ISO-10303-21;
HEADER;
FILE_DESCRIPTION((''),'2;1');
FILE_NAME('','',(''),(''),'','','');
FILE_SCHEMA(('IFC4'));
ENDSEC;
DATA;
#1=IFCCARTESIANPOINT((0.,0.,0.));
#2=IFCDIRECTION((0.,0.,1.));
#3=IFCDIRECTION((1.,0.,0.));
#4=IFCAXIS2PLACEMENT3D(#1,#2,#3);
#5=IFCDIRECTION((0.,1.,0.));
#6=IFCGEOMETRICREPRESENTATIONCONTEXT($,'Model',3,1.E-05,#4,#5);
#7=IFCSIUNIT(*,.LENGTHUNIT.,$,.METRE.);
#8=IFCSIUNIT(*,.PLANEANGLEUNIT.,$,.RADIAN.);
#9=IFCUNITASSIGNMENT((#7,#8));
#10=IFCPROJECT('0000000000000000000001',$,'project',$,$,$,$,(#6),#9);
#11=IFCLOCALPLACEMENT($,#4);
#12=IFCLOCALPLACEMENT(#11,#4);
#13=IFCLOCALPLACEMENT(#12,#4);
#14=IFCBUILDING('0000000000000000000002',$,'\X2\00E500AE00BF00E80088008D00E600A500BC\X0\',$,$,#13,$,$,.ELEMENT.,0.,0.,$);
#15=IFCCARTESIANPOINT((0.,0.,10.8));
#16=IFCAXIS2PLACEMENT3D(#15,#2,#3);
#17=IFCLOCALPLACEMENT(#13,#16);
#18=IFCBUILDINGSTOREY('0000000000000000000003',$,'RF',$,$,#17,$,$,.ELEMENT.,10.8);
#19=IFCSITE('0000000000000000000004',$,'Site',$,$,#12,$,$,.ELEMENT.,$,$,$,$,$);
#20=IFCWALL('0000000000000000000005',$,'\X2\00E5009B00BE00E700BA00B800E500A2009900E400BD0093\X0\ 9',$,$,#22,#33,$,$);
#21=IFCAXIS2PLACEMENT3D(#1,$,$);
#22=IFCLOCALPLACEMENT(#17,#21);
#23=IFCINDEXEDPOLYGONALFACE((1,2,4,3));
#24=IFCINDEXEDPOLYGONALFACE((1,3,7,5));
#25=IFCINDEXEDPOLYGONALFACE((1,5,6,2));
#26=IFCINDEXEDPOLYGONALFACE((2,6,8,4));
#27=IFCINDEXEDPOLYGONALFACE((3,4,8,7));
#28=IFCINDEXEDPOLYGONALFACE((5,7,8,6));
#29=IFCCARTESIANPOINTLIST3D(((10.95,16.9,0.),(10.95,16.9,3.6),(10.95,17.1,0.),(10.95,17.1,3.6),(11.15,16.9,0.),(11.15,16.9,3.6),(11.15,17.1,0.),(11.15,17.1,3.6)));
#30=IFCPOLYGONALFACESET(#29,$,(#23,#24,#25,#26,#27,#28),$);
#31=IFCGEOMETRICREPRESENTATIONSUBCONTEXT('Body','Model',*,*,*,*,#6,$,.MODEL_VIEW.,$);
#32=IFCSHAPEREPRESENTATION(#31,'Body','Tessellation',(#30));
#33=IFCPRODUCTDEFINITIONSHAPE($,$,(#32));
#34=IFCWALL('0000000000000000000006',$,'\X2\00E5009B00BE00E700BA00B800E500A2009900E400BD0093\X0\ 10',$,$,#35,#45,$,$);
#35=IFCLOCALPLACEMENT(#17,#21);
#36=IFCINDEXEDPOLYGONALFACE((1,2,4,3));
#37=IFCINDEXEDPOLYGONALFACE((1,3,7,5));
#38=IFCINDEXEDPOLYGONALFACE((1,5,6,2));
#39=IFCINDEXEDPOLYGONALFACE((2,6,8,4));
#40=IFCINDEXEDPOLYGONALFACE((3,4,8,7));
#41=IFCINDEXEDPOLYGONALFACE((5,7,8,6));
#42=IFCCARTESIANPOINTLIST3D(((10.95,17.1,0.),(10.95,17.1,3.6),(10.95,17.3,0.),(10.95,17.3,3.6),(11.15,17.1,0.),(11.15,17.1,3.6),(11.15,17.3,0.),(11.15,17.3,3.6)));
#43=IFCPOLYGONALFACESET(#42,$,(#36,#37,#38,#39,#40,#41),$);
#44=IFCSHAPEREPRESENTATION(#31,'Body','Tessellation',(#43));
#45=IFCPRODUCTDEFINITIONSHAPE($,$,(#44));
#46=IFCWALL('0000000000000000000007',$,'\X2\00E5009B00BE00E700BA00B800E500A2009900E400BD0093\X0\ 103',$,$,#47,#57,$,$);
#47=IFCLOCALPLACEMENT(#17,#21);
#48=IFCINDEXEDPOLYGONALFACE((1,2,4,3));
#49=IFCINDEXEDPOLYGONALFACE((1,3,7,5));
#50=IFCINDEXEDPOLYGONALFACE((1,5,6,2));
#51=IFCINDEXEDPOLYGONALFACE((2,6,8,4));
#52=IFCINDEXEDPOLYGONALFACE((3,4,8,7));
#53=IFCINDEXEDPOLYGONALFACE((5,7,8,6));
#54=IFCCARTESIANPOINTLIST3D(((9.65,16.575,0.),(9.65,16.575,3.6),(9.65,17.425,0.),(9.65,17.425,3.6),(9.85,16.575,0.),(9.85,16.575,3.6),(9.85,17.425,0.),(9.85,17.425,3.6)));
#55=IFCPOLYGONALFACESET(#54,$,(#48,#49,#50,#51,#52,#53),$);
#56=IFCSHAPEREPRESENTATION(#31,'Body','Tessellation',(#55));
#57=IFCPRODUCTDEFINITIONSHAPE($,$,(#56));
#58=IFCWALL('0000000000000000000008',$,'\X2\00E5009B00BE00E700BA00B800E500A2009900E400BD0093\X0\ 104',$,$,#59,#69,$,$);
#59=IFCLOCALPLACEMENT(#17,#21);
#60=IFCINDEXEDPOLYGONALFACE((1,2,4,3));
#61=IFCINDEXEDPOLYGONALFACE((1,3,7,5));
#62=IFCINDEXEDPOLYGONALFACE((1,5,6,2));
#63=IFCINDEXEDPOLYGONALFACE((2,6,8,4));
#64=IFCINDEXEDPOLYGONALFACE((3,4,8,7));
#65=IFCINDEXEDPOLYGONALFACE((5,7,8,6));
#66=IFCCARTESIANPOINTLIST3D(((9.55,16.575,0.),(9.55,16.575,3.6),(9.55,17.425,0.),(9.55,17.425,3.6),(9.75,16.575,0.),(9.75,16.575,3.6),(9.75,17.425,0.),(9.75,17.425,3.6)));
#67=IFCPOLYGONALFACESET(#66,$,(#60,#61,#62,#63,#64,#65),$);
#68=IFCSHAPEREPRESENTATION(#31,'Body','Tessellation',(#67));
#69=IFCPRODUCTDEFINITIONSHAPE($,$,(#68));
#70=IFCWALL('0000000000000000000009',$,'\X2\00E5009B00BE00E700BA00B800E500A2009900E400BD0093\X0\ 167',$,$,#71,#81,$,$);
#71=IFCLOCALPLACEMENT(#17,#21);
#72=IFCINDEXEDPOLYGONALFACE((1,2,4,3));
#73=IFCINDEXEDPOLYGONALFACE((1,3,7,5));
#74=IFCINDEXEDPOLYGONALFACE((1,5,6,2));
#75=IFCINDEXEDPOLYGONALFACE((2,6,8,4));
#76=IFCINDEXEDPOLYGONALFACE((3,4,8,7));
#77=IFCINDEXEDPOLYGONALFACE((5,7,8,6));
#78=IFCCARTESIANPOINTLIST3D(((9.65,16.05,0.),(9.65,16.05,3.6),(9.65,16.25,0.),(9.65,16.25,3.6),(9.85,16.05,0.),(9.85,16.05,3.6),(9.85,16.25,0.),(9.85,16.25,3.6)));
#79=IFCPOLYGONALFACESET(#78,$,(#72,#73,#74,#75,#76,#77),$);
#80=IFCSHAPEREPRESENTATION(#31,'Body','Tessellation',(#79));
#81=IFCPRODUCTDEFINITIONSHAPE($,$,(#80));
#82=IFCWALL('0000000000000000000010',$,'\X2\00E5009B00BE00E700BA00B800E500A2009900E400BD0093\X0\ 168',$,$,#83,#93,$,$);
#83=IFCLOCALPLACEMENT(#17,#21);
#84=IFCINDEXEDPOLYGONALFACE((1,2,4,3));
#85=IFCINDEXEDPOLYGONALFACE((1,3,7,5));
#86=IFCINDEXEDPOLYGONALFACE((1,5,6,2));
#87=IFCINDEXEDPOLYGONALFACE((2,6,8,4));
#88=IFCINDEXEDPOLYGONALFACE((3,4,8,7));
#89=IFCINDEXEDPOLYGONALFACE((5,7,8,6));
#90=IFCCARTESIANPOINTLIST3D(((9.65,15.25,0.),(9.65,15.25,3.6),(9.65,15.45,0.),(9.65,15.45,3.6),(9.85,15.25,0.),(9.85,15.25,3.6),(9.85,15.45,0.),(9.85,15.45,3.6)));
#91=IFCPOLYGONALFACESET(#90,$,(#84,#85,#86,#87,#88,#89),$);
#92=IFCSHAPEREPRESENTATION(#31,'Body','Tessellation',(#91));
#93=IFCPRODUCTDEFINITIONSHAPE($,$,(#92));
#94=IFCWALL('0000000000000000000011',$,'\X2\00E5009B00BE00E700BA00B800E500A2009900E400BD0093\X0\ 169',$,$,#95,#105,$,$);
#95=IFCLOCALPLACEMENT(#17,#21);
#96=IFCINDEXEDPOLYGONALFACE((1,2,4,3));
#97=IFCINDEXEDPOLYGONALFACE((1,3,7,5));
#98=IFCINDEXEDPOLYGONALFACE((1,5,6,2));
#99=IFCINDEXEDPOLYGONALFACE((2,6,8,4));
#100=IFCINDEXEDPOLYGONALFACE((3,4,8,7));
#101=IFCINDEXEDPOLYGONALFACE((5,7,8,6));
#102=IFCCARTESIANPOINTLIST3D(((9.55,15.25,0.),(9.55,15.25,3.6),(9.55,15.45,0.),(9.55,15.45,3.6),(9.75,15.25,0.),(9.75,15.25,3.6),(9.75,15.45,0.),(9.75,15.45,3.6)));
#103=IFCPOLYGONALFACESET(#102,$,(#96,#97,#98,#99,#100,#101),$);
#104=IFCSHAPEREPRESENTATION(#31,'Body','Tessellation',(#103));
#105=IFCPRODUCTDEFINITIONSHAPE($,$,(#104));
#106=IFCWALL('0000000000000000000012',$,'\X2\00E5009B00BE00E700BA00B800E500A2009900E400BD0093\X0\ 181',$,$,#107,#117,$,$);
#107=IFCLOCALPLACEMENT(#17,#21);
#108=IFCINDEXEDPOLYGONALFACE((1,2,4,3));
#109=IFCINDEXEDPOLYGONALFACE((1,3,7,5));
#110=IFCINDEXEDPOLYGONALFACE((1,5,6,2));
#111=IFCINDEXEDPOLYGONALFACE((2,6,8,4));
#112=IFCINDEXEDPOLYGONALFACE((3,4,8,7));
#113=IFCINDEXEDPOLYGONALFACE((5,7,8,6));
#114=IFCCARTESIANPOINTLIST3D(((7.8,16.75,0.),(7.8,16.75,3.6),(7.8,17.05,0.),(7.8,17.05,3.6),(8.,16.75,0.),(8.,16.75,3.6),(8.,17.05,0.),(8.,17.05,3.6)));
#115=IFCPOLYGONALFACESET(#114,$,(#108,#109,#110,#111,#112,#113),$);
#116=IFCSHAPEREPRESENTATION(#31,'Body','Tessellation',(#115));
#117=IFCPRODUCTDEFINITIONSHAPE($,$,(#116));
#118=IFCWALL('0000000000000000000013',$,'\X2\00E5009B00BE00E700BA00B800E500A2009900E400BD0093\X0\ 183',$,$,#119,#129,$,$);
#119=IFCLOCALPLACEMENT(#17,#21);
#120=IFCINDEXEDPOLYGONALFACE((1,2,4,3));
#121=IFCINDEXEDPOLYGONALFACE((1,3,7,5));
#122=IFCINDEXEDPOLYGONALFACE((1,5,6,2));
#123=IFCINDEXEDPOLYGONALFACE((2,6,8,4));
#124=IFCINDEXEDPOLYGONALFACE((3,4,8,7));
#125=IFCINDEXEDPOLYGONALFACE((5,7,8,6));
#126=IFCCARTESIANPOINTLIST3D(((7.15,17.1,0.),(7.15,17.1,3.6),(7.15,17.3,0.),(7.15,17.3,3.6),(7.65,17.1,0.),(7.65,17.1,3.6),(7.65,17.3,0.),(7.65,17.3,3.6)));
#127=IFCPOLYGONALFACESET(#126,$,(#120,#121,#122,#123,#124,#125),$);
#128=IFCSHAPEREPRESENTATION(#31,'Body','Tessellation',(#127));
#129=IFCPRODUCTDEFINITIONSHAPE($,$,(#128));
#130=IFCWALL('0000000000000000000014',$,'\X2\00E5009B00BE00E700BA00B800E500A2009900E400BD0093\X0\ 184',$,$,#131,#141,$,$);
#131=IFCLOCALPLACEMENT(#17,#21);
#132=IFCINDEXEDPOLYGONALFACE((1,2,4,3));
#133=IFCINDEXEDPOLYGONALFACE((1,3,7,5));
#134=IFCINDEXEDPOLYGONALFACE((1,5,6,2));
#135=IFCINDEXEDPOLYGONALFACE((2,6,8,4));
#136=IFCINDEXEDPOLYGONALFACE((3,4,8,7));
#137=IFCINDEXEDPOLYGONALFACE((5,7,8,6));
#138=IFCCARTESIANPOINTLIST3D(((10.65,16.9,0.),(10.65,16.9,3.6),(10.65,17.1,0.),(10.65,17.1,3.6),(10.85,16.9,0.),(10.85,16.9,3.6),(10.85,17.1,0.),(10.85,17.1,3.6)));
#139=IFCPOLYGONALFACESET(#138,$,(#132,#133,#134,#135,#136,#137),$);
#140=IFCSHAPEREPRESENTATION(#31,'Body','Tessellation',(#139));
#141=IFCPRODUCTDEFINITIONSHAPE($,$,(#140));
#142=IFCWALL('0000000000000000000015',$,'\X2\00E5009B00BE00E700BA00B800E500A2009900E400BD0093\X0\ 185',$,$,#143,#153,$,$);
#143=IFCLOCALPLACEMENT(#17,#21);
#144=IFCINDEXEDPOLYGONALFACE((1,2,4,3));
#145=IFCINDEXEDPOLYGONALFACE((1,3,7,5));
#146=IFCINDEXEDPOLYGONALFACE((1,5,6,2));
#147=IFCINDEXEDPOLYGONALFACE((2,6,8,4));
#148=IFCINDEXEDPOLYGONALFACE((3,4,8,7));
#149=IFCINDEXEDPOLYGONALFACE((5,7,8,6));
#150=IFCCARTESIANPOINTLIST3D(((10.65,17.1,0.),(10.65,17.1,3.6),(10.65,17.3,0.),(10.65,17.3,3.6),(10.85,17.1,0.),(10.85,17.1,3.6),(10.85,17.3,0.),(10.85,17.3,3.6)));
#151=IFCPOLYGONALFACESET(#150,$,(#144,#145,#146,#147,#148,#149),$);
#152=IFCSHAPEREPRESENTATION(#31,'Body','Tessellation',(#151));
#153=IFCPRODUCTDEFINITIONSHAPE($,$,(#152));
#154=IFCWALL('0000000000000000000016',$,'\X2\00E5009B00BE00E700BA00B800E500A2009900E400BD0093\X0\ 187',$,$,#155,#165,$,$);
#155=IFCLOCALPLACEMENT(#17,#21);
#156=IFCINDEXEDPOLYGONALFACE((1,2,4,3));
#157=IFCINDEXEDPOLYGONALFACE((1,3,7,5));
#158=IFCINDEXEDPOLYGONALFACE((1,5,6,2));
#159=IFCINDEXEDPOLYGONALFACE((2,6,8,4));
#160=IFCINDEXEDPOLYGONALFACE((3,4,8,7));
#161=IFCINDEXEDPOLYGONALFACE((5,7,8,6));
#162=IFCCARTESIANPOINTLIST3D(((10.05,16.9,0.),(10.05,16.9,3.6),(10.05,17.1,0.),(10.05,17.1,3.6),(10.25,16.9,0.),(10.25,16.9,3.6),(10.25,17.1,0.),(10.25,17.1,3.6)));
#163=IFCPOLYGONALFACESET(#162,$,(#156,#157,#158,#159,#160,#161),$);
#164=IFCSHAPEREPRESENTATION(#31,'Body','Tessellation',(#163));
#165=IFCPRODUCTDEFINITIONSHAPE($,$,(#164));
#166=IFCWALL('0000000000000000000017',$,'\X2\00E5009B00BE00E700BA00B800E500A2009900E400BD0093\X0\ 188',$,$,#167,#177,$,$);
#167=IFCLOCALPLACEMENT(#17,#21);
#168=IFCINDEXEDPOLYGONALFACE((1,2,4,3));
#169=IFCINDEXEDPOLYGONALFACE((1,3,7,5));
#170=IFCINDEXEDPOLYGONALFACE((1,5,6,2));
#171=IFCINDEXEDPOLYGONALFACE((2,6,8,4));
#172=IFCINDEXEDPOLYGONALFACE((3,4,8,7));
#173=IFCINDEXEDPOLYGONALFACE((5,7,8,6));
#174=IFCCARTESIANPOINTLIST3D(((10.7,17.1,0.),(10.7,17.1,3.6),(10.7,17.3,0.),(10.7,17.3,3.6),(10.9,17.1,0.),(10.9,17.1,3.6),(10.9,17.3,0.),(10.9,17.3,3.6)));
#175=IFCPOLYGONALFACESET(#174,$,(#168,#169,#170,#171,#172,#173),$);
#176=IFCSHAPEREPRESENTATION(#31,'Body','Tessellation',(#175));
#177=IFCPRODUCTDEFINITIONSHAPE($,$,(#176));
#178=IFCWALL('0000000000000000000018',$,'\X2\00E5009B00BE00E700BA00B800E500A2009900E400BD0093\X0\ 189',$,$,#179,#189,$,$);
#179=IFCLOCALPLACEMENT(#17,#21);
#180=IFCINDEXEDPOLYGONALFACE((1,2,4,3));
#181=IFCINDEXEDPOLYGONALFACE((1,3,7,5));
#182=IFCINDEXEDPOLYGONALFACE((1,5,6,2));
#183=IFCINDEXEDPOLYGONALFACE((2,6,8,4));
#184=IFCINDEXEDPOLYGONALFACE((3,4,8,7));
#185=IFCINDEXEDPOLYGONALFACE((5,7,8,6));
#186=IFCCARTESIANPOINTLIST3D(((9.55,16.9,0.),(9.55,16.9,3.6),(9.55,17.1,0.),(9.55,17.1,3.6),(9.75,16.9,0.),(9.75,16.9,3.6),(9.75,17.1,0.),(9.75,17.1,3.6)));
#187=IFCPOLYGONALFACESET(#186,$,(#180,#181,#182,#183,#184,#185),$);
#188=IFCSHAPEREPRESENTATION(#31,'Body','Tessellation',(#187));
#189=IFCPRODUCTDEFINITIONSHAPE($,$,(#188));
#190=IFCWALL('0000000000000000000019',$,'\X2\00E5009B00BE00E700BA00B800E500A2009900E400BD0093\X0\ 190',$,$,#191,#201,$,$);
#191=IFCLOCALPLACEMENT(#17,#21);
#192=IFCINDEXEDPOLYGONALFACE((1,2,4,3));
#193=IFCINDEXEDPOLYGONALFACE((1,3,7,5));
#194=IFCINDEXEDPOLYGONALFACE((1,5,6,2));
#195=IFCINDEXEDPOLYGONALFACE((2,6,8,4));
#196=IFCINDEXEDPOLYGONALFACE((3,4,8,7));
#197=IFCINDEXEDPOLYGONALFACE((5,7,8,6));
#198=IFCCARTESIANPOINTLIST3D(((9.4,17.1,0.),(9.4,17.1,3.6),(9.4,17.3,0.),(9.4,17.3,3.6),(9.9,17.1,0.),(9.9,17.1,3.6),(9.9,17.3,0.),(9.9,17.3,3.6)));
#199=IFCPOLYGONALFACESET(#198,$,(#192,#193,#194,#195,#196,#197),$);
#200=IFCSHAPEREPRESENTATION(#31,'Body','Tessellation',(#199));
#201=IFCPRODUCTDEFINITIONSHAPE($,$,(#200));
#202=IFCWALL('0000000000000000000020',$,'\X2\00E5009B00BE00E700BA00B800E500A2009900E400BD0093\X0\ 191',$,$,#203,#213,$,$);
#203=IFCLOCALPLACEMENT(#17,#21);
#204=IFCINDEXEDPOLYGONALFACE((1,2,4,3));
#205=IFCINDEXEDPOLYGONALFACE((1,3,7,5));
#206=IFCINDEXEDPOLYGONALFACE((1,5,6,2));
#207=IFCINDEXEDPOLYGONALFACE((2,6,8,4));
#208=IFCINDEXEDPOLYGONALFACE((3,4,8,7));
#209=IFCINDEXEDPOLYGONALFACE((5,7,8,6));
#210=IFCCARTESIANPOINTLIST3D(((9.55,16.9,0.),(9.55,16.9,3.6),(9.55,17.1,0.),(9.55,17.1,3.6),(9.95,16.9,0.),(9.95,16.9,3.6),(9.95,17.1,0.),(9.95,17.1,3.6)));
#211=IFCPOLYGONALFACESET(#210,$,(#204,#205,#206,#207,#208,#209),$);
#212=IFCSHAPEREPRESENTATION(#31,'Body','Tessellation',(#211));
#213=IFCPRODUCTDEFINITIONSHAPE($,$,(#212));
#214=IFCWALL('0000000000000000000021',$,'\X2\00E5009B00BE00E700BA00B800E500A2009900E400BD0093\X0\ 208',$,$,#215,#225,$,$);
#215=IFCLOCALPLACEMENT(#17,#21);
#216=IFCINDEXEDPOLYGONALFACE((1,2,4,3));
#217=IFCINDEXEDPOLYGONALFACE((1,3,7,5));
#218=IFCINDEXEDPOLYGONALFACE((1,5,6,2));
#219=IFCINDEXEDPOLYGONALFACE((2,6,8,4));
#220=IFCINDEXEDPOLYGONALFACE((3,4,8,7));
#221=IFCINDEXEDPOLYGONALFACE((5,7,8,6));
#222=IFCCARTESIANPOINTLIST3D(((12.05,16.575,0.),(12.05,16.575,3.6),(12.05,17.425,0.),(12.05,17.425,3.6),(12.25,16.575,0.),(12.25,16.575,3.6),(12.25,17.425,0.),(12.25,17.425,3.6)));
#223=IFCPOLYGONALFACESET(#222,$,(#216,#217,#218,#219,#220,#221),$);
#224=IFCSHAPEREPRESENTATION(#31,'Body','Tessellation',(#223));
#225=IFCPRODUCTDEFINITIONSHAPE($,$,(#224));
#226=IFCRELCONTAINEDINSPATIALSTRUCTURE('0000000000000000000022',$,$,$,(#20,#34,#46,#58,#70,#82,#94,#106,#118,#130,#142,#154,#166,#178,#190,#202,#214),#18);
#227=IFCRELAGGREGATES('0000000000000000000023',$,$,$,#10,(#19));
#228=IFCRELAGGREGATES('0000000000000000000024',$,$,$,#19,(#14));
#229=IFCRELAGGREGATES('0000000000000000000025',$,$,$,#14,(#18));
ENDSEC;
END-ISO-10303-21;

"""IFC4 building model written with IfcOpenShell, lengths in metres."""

from ifc_helpers import new_model, si_unit, direction, frame, frame_2d, origin_with_axes, place, context, subcontext, project, spatial, rectangle, extrude, element, save


model = new_model("IFC4")

# Units and contexts
model_context = context("Model", 3, precision=1e-05, world=origin_with_axes(), true_north=direction((0.0, 1.0, 0.0)))
body_context = subcontext(model_context, "Body", "Model", "MODEL_VIEW")
ifc_project = project(units=[si_unit("LENGTHUNIT", "METRE"), si_unit("PLANEANGLEUNIT", "RADIAN")], contexts=[model_context])

# Site, building, storey
placement = place(None, origin_with_axes())
site_placement = place(placement, origin_with_axes())
site = spatial("IfcSite", under=ifc_project, at=site_placement, Name="Site", CompositionType="ELEMENT")
building_placement = place(site_placement, origin_with_axes())
building = spatial("IfcBuilding", under=site, at=building_placement, Name="å®¿è\u0088\u008dæ¥¼", CompositionType="ELEMENT", ElevationOfRefHeight=0.0, ElevationOfTerrain=0.0)
storey_placement = place(building_placement, frame((0.0, 0.0, 10.8), z_axis=(0.0, 0.0, 1.0), x_axis=(1.0, 0.0, 0.0)))
storey = spatial("IfcBuildingStorey", under=building, at=storey_placement, Name="RF", CompositionType="ELEMENT", Elevation=10.8)

# Walls
for number, where, z_axis, x_axis, name in (
    (1, (11.05, 17.0, 0.0), (0.0, 0.0, 1.0), (-1.0, 0.0, 0.0), "å\u009b¾çº¸å¢\u0099ä½\u0093 9"),
    (2, (11.05, 17.2, 0.0), (0.0, 0.0, 1.0), (-1.0, 0.0, 0.0), "å\u009b¾çº¸å¢\u0099ä½\u0093 10"),
):
    element("IfcWall", number, at=place(storey_placement, frame(where, z_axis=z_axis, x_axis=x_axis)), inside=storey, Name=name, context=body_context, shape_type="SweptSolid", body=[
        extrude(rectangle(XDim=0.2, YDim=0.2, at=frame_2d((0.0, 0.0), x_axis=(1.0, 0.0, 0.0))), frame((0.0, 0.0, 0.0), z_axis=(0.0, 0.0, 1.0)), (0.0, 0.0, 1.0), 3.6),
    ])
for number, where, z_axis, x_axis, name in (
    (3, (9.75, 17.0, 0.0), (0.0, 0.0, 1.0), (0.0, -1.0, 0.0), "å\u009b¾çº¸å¢\u0099ä½\u0093 103"),
    (4, (9.65, 17.0, 0.0), (0.0, 0.0, 1.0), (0.0, -1.0, 0.0), "å\u009b¾çº¸å¢\u0099ä½\u0093 104"),
):
    element("IfcWall", number, at=place(storey_placement, frame(where, z_axis=z_axis, x_axis=x_axis)), inside=storey, Name=name, context=body_context, shape_type="SweptSolid", body=[
        extrude(rectangle(XDim=0.85, YDim=0.2, at=frame_2d((0.0, 0.0), x_axis=(1.0, 0.0, 0.0))), frame((0.0, 0.0, 0.0), z_axis=(0.0, 0.0, 1.0)), (0.0, 0.0, 1.0), 3.6),
    ])
for number, where, z_axis, x_axis, name in (
    (5, (9.75, 16.15, 0.0), (0.0, 0.0, 1.0), (-1.0, 0.0, 0.0), "å\u009b¾çº¸å¢\u0099ä½\u0093 167"),
    (6, (9.75, 15.35, 0.0), (0.0, 0.0, 1.0), (0.0, -1.0, 0.0), "å\u009b¾çº¸å¢\u0099ä½\u0093 168"),
    (7, (9.65, 15.35, 0.0), (0.0, 0.0, 1.0), (0.0, -1.0, 0.0), "å\u009b¾çº¸å¢\u0099ä½\u0093 169"),
):
    element("IfcWall", number, at=place(storey_placement, frame(where, z_axis=z_axis, x_axis=x_axis)), inside=storey, Name=name, context=body_context, shape_type="SweptSolid", body=[
        extrude(rectangle(XDim=0.2, YDim=0.2, at=frame_2d((0.0, 0.0), x_axis=(1.0, 0.0, 0.0))), frame((0.0, 0.0, 0.0), z_axis=(0.0, 0.0, 1.0)), (0.0, 0.0, 1.0), 3.6),
    ])
wall_1_placement = place(storey_placement, frame((7.9, 16.9, 0.0), z_axis=(0.0, 0.0, 1.0), x_axis=(0.0, 1.0, 0.0)))
element("IfcWall", 8, at=wall_1_placement, inside=storey, Name="å\u009b¾çº¸å¢\u0099ä½\u0093 181", context=body_context, shape_type="SweptSolid", body=[
    extrude(rectangle(XDim=0.3, YDim=0.2, at=frame_2d((0.0, 0.0), x_axis=(1.0, 0.0, 0.0))), frame((0.0, 0.0, 0.0), z_axis=(0.0, 0.0, 1.0)), (0.0, 0.0, 1.0), 3.6),
])
wall_2_placement = place(storey_placement, frame((7.4, 17.2, 0.0), z_axis=(0.0, 0.0, 1.0), x_axis=(1.0, 0.0, 0.0)))
element("IfcWall", 9, at=wall_2_placement, inside=storey, Name="å\u009b¾çº¸å¢\u0099ä½\u0093 183", context=body_context, shape_type="SweptSolid", body=[
    extrude(rectangle(XDim=0.5, YDim=0.2, at=frame_2d((0.0, 0.0), x_axis=(1.0, 0.0, 0.0))), frame((0.0, 0.0, 0.0), z_axis=(0.0, 0.0, 1.0)), (0.0, 0.0, 1.0), 3.6),
])
for number, where, z_axis, x_axis, name in (
    (10, (10.75, 17.0, 0.0), (0.0, 0.0, 1.0), (1.0, 0.0, 0.0), "å\u009b¾çº¸å¢\u0099ä½\u0093 184"),
    (11, (10.75, 17.2, 0.0), (0.0, 0.0, 1.0), (1.0, 0.0, 0.0), "å\u009b¾çº¸å¢\u0099ä½\u0093 185"),
    (12, (10.15, 17.0, 0.0), (0.0, 0.0, 1.0), (0.0, 1.0, 0.0), "å\u009b¾çº¸å¢\u0099ä½\u0093 187"),
    (13, (10.8, 17.2, 0.0), (0.0, 0.0, 1.0), (1.0, 0.0, 0.0), "å\u009b¾çº¸å¢\u0099ä½\u0093 188"),
    (14, (9.65, 17.0, 0.0), (0.0, 0.0, 1.0), (0.0, 1.0, 0.0), "å\u009b¾çº¸å¢\u0099ä½\u0093 189"),
):
    element("IfcWall", number, at=place(storey_placement, frame(where, z_axis=z_axis, x_axis=x_axis)), inside=storey, Name=name, context=body_context, shape_type="SweptSolid", body=[
        extrude(rectangle(XDim=0.2, YDim=0.2, at=frame_2d((0.0, 0.0), x_axis=(1.0, 0.0, 0.0))), frame((0.0, 0.0, 0.0), z_axis=(0.0, 0.0, 1.0)), (0.0, 0.0, 1.0), 3.6),
    ])
wall_3_placement = place(storey_placement, frame((9.65, 17.2, 0.0), z_axis=(0.0, 0.0, 1.0), x_axis=(1.0, 0.0, 0.0)))
element("IfcWall", 15, at=wall_3_placement, inside=storey, Name="å\u009b¾çº¸å¢\u0099ä½\u0093 190", context=body_context, shape_type="SweptSolid", body=[
    extrude(rectangle(XDim=0.5, YDim=0.2, at=frame_2d((0.0, 0.0), x_axis=(1.0, 0.0, 0.0))), frame((0.0, 0.0, 0.0), z_axis=(0.0, 0.0, 1.0)), (0.0, 0.0, 1.0), 3.6),
])
wall_4_placement = place(storey_placement, frame((9.75, 17.0, 0.0), z_axis=(0.0, 0.0, 1.0), x_axis=(1.0, 0.0, 0.0)))
element("IfcWall", 16, at=wall_4_placement, inside=storey, Name="å\u009b¾çº¸å¢\u0099ä½\u0093 191", context=body_context, shape_type="SweptSolid", body=[
    extrude(rectangle(XDim=0.4, YDim=0.2, at=frame_2d((0.0, 0.0), x_axis=(1.0, 0.0, 0.0))), frame((0.0, 0.0, 0.0), z_axis=(0.0, 0.0, 1.0)), (0.0, 0.0, 1.0), 3.6),
])
for number, where, z_axis, x_axis, name in (
    (17, (12.15, 17.0, 0.0), (0.0, 0.0, 1.0), (0.0, -1.0, 0.0), "å\u009b¾çº¸å¢\u0099ä½\u0093 208"),
):
    element("IfcWall", number, at=place(storey_placement, frame(where, z_axis=z_axis, x_axis=x_axis)), inside=storey, Name=name, context=body_context, shape_type="SweptSolid", body=[
        extrude(rectangle(XDim=0.85, YDim=0.2, at=frame_2d((0.0, 0.0), x_axis=(1.0, 0.0, 0.0))), frame((0.0, 0.0, 0.0), z_axis=(0.0, 0.0, 1.0)), (0.0, 0.0, 1.0), 3.6),
    ])

save(model, "model.ifc")
